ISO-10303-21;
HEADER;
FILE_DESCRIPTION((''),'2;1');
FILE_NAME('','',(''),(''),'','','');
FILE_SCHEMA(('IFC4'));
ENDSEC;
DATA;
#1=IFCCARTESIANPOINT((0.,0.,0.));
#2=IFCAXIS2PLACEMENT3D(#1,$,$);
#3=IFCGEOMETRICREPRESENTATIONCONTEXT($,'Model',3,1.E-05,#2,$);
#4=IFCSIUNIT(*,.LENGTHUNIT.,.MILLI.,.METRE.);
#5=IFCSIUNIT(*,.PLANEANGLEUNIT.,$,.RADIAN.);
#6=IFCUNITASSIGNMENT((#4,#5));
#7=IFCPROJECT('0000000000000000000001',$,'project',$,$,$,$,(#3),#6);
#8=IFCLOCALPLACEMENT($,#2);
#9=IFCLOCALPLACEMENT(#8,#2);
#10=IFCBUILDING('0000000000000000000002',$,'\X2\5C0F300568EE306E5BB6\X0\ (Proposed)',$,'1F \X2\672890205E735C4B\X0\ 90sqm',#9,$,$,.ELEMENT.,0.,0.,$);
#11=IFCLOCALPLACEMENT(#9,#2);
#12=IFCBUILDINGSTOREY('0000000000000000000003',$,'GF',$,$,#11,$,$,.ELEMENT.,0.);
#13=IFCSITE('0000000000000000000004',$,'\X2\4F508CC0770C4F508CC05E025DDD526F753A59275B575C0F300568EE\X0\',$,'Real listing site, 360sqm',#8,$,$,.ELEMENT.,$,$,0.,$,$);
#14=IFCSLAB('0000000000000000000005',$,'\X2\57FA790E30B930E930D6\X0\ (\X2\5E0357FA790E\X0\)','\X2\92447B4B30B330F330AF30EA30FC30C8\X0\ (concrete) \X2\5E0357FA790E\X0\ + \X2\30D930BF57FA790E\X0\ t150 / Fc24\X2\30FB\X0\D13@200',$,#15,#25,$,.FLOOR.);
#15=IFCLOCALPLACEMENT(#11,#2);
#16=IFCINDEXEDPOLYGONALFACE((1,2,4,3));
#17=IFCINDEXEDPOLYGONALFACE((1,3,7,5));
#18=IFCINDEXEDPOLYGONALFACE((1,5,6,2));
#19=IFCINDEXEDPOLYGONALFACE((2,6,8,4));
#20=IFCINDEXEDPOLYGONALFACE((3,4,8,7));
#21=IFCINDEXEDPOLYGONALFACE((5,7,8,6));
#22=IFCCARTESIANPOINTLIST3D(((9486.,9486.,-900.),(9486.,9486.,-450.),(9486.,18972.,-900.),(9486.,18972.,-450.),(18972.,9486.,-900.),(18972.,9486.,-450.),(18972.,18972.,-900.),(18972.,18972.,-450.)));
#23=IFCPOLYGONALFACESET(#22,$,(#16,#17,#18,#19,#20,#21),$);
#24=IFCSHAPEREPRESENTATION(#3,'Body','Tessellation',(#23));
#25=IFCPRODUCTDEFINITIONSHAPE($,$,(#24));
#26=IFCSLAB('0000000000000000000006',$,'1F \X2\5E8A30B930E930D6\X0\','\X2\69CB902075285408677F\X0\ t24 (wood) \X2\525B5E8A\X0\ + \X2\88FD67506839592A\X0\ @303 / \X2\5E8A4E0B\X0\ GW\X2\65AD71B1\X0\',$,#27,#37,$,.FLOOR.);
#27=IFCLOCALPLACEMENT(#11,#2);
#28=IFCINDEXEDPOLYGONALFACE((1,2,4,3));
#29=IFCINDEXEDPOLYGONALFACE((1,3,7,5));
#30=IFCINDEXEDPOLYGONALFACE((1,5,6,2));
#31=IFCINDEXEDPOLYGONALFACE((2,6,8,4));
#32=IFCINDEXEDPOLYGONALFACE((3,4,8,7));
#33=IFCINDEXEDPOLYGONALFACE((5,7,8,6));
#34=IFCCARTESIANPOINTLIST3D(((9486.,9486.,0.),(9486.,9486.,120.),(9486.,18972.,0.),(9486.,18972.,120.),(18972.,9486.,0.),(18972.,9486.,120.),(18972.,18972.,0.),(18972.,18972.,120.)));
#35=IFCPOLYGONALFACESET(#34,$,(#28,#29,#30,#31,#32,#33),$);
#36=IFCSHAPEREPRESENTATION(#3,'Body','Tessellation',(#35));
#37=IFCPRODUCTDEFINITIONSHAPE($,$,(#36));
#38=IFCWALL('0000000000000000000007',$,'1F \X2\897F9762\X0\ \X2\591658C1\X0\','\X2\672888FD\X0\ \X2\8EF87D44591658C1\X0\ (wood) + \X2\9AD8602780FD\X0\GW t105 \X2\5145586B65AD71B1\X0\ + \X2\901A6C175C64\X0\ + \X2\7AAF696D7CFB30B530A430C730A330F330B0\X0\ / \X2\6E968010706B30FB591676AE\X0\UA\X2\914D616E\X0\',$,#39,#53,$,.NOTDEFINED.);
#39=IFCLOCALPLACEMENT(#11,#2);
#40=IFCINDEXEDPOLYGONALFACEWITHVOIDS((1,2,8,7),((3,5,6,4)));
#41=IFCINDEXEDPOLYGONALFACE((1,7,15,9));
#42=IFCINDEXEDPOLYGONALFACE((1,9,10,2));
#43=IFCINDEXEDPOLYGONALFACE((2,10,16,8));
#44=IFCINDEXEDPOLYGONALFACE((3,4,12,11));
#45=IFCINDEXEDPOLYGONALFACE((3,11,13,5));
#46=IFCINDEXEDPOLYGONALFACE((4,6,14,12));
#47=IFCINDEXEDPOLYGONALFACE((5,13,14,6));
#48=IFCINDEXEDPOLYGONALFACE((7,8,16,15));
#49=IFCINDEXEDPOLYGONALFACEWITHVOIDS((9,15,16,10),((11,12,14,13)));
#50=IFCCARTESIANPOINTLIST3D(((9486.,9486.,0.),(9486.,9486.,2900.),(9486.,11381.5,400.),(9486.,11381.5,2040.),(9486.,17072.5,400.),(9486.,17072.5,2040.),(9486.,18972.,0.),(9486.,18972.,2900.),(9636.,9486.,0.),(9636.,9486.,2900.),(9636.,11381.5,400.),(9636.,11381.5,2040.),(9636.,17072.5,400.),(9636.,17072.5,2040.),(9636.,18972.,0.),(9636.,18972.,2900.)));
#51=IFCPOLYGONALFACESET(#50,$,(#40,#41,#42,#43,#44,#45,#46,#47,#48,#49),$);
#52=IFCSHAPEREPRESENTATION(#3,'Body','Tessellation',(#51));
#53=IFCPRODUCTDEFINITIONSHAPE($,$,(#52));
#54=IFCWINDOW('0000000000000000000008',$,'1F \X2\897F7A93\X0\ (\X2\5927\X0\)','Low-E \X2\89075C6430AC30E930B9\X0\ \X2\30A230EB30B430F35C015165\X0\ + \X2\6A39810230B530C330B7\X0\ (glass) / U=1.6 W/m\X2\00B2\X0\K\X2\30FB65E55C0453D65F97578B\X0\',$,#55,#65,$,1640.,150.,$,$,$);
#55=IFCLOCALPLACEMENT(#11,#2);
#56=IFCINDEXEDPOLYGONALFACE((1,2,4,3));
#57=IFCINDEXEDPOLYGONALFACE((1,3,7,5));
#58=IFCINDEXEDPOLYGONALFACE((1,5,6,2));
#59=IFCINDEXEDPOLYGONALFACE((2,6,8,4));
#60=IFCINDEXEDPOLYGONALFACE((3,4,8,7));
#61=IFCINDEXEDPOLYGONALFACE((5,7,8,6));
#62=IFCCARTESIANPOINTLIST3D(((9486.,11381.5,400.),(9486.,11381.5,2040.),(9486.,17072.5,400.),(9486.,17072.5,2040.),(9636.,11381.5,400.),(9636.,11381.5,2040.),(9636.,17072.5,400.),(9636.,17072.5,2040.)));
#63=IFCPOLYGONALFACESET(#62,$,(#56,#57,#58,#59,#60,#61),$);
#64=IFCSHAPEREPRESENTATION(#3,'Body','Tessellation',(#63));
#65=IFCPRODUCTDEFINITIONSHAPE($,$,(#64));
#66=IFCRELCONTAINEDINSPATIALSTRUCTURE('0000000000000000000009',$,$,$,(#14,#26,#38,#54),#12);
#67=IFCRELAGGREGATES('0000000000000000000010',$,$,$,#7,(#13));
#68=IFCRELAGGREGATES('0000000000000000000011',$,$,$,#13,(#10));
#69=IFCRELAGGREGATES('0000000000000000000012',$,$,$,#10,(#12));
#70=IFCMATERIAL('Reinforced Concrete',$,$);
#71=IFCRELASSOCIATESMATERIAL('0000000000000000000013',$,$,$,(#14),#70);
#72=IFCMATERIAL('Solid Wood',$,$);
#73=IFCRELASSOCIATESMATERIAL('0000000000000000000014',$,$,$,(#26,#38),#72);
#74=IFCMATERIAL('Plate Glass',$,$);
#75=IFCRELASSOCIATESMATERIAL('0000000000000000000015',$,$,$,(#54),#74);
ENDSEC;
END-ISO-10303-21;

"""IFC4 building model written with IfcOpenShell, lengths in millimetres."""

from ifc_helpers import new_model, si_unit, frame, frame_2d, origin, place, context, project, spatial, rectangle, extrude, material, element, fill, save


model = new_model("IFC4")

# Units and contexts
model_context = context("Model", 3, precision=1e-05, world=origin())
ifc_project = project(units=[si_unit("LENGTHUNIT", "METRE", prefix="MILLI"), si_unit("PLANEANGLEUNIT", "RADIAN")], contexts=[model_context])

# Site, building, storey
site_placement = place(None, origin())
site = spatial("IfcSite", under=ifc_project, at=site_placement, Name="佐賀県佐賀市川副町大字小々森", ObjectType="Real listing site, 360sqm", CompositionType="ELEMENT", RefElevation=0.0)
building_placement = place(site_placement, origin())
building = spatial("IfcBuilding", under=site, at=building_placement, Name="小々森の家 (Proposed)", ObjectType="1F 木造平屋 90sqm", CompositionType="ELEMENT", ElevationOfRefHeight=0.0, ElevationOfTerrain=0.0)
storey_placement = place(building_placement, origin())
storey = spatial("IfcBuildingStorey", under=building, at=storey_placement, Name="GF", CompositionType="ELEMENT", Elevation=0.0)

# Slabs
ifc_material_1 = material(Name="Reinforced Concrete")
slab_1_placement = place(storey_placement, frame((4743.0, 4743.0, -450.0)))
element("IfcSlab", 1, at=slab_1_placement, inside=storey, material=ifc_material_1, Name="基礎スラブ (布基礎)", Description="鉄筋コンクリート (concrete) 布基礎 + ベタ基礎 t150 / Fc24・D13@200", PredefinedType="FLOOR", context=model_context, shape_type="SweptSolid", body=[
    extrude(rectangle(XDim=9486.0, YDim=9486.0, at=frame_2d((4743.0, 4743.0))), frame((4743.0, 4743.0, -450.0)), (0.0, 0.0, 1.0), 450.0),
])
ifc_material_2 = material(Name="Solid Wood")
slab_2_placement = place(storey_placement, frame((4743.0, 4743.0, 0.0)))
element("IfcSlab", 2, at=slab_2_placement, inside=storey, material=ifc_material_2, Name="1F 床スラブ", Description="構造用合板 t24 (wood) 剛床 + 製材根太 @303 / 床下 GW断熱", PredefinedType="FLOOR", context=model_context, shape_type="SweptSolid", body=[
    extrude(rectangle(XDim=9486.0, YDim=9486.0, at=frame_2d((4743.0, 4743.0))), frame((4743.0, 4743.0, 0.0)), (0.0, 0.0, 1.0), 120.0),
])

# Shared definitions
ifc_material_3 = material(Name="Plate Glass")

# Wall, opening, window
wall_1_placement = place(storey_placement, frame((4743.0, 4743.0, 0.0)))
wall_1 = element("IfcWall", 3, at=wall_1_placement, inside=storey, material=ifc_material_2, Name="1F 西面 外壁", Description="木製 軸組外壁 (wood) + 高性能GW t105 充填断熱 + 通気層 + 窯業系サイディング / 準耐火・外皮UA配慮", PredefinedType="NOTDEFINED", context=model_context, shape_type="SweptSolid", body=[
    extrude(rectangle(XDim=150.0, YDim=9486.0, at=frame_2d((75.0, 4743.0))), frame((4743.0, 4743.0, 0.0)), (0.0, 0.0, 1.0), 2900.0),
])
opening_1_placement = place(storey_placement, frame((4743.0, 5691.0, 200.0)))
opening_1 = element("IfcOpeningElement", 4, at=opening_1_placement, cuts=wall_1, PredefinedType="NOTDEFINED", context=model_context, shape_type="SweptSolid", body=[
    extrude(rectangle(XDim=150.0, YDim=5691.0, at=frame_2d((75.0, 2845.0))), frame((4743.0, 5691.0, 200.0)), (0.0, 0.0, 1.0), 1640.0),
])
window_1_placement = place(storey_placement, frame((4743.0, 5691.0, 200.0)))
window_1 = element("IfcWindow", 5, at=window_1_placement, inside=storey, material=ifc_material_3, Name="1F 西窓 (大)", Description="Low-E 複層ガラス アルゴン封入 + 樹脂サッシ (glass) / U=1.6 W/m²K・日射取得型", OverallHeight=1640.0, OverallWidth=150.0, context=model_context, shape_type="SweptSolid", body=[
    extrude(rectangle(XDim=150.0, YDim=5691.0, at=frame_2d((75.0, 2845.0))), frame((4743.0, 5691.0, 200.0)), (0.0, 0.0, 1.0), 1640.0),
])
fill(opening_1, window_1)

save(model, "model.ifc")
